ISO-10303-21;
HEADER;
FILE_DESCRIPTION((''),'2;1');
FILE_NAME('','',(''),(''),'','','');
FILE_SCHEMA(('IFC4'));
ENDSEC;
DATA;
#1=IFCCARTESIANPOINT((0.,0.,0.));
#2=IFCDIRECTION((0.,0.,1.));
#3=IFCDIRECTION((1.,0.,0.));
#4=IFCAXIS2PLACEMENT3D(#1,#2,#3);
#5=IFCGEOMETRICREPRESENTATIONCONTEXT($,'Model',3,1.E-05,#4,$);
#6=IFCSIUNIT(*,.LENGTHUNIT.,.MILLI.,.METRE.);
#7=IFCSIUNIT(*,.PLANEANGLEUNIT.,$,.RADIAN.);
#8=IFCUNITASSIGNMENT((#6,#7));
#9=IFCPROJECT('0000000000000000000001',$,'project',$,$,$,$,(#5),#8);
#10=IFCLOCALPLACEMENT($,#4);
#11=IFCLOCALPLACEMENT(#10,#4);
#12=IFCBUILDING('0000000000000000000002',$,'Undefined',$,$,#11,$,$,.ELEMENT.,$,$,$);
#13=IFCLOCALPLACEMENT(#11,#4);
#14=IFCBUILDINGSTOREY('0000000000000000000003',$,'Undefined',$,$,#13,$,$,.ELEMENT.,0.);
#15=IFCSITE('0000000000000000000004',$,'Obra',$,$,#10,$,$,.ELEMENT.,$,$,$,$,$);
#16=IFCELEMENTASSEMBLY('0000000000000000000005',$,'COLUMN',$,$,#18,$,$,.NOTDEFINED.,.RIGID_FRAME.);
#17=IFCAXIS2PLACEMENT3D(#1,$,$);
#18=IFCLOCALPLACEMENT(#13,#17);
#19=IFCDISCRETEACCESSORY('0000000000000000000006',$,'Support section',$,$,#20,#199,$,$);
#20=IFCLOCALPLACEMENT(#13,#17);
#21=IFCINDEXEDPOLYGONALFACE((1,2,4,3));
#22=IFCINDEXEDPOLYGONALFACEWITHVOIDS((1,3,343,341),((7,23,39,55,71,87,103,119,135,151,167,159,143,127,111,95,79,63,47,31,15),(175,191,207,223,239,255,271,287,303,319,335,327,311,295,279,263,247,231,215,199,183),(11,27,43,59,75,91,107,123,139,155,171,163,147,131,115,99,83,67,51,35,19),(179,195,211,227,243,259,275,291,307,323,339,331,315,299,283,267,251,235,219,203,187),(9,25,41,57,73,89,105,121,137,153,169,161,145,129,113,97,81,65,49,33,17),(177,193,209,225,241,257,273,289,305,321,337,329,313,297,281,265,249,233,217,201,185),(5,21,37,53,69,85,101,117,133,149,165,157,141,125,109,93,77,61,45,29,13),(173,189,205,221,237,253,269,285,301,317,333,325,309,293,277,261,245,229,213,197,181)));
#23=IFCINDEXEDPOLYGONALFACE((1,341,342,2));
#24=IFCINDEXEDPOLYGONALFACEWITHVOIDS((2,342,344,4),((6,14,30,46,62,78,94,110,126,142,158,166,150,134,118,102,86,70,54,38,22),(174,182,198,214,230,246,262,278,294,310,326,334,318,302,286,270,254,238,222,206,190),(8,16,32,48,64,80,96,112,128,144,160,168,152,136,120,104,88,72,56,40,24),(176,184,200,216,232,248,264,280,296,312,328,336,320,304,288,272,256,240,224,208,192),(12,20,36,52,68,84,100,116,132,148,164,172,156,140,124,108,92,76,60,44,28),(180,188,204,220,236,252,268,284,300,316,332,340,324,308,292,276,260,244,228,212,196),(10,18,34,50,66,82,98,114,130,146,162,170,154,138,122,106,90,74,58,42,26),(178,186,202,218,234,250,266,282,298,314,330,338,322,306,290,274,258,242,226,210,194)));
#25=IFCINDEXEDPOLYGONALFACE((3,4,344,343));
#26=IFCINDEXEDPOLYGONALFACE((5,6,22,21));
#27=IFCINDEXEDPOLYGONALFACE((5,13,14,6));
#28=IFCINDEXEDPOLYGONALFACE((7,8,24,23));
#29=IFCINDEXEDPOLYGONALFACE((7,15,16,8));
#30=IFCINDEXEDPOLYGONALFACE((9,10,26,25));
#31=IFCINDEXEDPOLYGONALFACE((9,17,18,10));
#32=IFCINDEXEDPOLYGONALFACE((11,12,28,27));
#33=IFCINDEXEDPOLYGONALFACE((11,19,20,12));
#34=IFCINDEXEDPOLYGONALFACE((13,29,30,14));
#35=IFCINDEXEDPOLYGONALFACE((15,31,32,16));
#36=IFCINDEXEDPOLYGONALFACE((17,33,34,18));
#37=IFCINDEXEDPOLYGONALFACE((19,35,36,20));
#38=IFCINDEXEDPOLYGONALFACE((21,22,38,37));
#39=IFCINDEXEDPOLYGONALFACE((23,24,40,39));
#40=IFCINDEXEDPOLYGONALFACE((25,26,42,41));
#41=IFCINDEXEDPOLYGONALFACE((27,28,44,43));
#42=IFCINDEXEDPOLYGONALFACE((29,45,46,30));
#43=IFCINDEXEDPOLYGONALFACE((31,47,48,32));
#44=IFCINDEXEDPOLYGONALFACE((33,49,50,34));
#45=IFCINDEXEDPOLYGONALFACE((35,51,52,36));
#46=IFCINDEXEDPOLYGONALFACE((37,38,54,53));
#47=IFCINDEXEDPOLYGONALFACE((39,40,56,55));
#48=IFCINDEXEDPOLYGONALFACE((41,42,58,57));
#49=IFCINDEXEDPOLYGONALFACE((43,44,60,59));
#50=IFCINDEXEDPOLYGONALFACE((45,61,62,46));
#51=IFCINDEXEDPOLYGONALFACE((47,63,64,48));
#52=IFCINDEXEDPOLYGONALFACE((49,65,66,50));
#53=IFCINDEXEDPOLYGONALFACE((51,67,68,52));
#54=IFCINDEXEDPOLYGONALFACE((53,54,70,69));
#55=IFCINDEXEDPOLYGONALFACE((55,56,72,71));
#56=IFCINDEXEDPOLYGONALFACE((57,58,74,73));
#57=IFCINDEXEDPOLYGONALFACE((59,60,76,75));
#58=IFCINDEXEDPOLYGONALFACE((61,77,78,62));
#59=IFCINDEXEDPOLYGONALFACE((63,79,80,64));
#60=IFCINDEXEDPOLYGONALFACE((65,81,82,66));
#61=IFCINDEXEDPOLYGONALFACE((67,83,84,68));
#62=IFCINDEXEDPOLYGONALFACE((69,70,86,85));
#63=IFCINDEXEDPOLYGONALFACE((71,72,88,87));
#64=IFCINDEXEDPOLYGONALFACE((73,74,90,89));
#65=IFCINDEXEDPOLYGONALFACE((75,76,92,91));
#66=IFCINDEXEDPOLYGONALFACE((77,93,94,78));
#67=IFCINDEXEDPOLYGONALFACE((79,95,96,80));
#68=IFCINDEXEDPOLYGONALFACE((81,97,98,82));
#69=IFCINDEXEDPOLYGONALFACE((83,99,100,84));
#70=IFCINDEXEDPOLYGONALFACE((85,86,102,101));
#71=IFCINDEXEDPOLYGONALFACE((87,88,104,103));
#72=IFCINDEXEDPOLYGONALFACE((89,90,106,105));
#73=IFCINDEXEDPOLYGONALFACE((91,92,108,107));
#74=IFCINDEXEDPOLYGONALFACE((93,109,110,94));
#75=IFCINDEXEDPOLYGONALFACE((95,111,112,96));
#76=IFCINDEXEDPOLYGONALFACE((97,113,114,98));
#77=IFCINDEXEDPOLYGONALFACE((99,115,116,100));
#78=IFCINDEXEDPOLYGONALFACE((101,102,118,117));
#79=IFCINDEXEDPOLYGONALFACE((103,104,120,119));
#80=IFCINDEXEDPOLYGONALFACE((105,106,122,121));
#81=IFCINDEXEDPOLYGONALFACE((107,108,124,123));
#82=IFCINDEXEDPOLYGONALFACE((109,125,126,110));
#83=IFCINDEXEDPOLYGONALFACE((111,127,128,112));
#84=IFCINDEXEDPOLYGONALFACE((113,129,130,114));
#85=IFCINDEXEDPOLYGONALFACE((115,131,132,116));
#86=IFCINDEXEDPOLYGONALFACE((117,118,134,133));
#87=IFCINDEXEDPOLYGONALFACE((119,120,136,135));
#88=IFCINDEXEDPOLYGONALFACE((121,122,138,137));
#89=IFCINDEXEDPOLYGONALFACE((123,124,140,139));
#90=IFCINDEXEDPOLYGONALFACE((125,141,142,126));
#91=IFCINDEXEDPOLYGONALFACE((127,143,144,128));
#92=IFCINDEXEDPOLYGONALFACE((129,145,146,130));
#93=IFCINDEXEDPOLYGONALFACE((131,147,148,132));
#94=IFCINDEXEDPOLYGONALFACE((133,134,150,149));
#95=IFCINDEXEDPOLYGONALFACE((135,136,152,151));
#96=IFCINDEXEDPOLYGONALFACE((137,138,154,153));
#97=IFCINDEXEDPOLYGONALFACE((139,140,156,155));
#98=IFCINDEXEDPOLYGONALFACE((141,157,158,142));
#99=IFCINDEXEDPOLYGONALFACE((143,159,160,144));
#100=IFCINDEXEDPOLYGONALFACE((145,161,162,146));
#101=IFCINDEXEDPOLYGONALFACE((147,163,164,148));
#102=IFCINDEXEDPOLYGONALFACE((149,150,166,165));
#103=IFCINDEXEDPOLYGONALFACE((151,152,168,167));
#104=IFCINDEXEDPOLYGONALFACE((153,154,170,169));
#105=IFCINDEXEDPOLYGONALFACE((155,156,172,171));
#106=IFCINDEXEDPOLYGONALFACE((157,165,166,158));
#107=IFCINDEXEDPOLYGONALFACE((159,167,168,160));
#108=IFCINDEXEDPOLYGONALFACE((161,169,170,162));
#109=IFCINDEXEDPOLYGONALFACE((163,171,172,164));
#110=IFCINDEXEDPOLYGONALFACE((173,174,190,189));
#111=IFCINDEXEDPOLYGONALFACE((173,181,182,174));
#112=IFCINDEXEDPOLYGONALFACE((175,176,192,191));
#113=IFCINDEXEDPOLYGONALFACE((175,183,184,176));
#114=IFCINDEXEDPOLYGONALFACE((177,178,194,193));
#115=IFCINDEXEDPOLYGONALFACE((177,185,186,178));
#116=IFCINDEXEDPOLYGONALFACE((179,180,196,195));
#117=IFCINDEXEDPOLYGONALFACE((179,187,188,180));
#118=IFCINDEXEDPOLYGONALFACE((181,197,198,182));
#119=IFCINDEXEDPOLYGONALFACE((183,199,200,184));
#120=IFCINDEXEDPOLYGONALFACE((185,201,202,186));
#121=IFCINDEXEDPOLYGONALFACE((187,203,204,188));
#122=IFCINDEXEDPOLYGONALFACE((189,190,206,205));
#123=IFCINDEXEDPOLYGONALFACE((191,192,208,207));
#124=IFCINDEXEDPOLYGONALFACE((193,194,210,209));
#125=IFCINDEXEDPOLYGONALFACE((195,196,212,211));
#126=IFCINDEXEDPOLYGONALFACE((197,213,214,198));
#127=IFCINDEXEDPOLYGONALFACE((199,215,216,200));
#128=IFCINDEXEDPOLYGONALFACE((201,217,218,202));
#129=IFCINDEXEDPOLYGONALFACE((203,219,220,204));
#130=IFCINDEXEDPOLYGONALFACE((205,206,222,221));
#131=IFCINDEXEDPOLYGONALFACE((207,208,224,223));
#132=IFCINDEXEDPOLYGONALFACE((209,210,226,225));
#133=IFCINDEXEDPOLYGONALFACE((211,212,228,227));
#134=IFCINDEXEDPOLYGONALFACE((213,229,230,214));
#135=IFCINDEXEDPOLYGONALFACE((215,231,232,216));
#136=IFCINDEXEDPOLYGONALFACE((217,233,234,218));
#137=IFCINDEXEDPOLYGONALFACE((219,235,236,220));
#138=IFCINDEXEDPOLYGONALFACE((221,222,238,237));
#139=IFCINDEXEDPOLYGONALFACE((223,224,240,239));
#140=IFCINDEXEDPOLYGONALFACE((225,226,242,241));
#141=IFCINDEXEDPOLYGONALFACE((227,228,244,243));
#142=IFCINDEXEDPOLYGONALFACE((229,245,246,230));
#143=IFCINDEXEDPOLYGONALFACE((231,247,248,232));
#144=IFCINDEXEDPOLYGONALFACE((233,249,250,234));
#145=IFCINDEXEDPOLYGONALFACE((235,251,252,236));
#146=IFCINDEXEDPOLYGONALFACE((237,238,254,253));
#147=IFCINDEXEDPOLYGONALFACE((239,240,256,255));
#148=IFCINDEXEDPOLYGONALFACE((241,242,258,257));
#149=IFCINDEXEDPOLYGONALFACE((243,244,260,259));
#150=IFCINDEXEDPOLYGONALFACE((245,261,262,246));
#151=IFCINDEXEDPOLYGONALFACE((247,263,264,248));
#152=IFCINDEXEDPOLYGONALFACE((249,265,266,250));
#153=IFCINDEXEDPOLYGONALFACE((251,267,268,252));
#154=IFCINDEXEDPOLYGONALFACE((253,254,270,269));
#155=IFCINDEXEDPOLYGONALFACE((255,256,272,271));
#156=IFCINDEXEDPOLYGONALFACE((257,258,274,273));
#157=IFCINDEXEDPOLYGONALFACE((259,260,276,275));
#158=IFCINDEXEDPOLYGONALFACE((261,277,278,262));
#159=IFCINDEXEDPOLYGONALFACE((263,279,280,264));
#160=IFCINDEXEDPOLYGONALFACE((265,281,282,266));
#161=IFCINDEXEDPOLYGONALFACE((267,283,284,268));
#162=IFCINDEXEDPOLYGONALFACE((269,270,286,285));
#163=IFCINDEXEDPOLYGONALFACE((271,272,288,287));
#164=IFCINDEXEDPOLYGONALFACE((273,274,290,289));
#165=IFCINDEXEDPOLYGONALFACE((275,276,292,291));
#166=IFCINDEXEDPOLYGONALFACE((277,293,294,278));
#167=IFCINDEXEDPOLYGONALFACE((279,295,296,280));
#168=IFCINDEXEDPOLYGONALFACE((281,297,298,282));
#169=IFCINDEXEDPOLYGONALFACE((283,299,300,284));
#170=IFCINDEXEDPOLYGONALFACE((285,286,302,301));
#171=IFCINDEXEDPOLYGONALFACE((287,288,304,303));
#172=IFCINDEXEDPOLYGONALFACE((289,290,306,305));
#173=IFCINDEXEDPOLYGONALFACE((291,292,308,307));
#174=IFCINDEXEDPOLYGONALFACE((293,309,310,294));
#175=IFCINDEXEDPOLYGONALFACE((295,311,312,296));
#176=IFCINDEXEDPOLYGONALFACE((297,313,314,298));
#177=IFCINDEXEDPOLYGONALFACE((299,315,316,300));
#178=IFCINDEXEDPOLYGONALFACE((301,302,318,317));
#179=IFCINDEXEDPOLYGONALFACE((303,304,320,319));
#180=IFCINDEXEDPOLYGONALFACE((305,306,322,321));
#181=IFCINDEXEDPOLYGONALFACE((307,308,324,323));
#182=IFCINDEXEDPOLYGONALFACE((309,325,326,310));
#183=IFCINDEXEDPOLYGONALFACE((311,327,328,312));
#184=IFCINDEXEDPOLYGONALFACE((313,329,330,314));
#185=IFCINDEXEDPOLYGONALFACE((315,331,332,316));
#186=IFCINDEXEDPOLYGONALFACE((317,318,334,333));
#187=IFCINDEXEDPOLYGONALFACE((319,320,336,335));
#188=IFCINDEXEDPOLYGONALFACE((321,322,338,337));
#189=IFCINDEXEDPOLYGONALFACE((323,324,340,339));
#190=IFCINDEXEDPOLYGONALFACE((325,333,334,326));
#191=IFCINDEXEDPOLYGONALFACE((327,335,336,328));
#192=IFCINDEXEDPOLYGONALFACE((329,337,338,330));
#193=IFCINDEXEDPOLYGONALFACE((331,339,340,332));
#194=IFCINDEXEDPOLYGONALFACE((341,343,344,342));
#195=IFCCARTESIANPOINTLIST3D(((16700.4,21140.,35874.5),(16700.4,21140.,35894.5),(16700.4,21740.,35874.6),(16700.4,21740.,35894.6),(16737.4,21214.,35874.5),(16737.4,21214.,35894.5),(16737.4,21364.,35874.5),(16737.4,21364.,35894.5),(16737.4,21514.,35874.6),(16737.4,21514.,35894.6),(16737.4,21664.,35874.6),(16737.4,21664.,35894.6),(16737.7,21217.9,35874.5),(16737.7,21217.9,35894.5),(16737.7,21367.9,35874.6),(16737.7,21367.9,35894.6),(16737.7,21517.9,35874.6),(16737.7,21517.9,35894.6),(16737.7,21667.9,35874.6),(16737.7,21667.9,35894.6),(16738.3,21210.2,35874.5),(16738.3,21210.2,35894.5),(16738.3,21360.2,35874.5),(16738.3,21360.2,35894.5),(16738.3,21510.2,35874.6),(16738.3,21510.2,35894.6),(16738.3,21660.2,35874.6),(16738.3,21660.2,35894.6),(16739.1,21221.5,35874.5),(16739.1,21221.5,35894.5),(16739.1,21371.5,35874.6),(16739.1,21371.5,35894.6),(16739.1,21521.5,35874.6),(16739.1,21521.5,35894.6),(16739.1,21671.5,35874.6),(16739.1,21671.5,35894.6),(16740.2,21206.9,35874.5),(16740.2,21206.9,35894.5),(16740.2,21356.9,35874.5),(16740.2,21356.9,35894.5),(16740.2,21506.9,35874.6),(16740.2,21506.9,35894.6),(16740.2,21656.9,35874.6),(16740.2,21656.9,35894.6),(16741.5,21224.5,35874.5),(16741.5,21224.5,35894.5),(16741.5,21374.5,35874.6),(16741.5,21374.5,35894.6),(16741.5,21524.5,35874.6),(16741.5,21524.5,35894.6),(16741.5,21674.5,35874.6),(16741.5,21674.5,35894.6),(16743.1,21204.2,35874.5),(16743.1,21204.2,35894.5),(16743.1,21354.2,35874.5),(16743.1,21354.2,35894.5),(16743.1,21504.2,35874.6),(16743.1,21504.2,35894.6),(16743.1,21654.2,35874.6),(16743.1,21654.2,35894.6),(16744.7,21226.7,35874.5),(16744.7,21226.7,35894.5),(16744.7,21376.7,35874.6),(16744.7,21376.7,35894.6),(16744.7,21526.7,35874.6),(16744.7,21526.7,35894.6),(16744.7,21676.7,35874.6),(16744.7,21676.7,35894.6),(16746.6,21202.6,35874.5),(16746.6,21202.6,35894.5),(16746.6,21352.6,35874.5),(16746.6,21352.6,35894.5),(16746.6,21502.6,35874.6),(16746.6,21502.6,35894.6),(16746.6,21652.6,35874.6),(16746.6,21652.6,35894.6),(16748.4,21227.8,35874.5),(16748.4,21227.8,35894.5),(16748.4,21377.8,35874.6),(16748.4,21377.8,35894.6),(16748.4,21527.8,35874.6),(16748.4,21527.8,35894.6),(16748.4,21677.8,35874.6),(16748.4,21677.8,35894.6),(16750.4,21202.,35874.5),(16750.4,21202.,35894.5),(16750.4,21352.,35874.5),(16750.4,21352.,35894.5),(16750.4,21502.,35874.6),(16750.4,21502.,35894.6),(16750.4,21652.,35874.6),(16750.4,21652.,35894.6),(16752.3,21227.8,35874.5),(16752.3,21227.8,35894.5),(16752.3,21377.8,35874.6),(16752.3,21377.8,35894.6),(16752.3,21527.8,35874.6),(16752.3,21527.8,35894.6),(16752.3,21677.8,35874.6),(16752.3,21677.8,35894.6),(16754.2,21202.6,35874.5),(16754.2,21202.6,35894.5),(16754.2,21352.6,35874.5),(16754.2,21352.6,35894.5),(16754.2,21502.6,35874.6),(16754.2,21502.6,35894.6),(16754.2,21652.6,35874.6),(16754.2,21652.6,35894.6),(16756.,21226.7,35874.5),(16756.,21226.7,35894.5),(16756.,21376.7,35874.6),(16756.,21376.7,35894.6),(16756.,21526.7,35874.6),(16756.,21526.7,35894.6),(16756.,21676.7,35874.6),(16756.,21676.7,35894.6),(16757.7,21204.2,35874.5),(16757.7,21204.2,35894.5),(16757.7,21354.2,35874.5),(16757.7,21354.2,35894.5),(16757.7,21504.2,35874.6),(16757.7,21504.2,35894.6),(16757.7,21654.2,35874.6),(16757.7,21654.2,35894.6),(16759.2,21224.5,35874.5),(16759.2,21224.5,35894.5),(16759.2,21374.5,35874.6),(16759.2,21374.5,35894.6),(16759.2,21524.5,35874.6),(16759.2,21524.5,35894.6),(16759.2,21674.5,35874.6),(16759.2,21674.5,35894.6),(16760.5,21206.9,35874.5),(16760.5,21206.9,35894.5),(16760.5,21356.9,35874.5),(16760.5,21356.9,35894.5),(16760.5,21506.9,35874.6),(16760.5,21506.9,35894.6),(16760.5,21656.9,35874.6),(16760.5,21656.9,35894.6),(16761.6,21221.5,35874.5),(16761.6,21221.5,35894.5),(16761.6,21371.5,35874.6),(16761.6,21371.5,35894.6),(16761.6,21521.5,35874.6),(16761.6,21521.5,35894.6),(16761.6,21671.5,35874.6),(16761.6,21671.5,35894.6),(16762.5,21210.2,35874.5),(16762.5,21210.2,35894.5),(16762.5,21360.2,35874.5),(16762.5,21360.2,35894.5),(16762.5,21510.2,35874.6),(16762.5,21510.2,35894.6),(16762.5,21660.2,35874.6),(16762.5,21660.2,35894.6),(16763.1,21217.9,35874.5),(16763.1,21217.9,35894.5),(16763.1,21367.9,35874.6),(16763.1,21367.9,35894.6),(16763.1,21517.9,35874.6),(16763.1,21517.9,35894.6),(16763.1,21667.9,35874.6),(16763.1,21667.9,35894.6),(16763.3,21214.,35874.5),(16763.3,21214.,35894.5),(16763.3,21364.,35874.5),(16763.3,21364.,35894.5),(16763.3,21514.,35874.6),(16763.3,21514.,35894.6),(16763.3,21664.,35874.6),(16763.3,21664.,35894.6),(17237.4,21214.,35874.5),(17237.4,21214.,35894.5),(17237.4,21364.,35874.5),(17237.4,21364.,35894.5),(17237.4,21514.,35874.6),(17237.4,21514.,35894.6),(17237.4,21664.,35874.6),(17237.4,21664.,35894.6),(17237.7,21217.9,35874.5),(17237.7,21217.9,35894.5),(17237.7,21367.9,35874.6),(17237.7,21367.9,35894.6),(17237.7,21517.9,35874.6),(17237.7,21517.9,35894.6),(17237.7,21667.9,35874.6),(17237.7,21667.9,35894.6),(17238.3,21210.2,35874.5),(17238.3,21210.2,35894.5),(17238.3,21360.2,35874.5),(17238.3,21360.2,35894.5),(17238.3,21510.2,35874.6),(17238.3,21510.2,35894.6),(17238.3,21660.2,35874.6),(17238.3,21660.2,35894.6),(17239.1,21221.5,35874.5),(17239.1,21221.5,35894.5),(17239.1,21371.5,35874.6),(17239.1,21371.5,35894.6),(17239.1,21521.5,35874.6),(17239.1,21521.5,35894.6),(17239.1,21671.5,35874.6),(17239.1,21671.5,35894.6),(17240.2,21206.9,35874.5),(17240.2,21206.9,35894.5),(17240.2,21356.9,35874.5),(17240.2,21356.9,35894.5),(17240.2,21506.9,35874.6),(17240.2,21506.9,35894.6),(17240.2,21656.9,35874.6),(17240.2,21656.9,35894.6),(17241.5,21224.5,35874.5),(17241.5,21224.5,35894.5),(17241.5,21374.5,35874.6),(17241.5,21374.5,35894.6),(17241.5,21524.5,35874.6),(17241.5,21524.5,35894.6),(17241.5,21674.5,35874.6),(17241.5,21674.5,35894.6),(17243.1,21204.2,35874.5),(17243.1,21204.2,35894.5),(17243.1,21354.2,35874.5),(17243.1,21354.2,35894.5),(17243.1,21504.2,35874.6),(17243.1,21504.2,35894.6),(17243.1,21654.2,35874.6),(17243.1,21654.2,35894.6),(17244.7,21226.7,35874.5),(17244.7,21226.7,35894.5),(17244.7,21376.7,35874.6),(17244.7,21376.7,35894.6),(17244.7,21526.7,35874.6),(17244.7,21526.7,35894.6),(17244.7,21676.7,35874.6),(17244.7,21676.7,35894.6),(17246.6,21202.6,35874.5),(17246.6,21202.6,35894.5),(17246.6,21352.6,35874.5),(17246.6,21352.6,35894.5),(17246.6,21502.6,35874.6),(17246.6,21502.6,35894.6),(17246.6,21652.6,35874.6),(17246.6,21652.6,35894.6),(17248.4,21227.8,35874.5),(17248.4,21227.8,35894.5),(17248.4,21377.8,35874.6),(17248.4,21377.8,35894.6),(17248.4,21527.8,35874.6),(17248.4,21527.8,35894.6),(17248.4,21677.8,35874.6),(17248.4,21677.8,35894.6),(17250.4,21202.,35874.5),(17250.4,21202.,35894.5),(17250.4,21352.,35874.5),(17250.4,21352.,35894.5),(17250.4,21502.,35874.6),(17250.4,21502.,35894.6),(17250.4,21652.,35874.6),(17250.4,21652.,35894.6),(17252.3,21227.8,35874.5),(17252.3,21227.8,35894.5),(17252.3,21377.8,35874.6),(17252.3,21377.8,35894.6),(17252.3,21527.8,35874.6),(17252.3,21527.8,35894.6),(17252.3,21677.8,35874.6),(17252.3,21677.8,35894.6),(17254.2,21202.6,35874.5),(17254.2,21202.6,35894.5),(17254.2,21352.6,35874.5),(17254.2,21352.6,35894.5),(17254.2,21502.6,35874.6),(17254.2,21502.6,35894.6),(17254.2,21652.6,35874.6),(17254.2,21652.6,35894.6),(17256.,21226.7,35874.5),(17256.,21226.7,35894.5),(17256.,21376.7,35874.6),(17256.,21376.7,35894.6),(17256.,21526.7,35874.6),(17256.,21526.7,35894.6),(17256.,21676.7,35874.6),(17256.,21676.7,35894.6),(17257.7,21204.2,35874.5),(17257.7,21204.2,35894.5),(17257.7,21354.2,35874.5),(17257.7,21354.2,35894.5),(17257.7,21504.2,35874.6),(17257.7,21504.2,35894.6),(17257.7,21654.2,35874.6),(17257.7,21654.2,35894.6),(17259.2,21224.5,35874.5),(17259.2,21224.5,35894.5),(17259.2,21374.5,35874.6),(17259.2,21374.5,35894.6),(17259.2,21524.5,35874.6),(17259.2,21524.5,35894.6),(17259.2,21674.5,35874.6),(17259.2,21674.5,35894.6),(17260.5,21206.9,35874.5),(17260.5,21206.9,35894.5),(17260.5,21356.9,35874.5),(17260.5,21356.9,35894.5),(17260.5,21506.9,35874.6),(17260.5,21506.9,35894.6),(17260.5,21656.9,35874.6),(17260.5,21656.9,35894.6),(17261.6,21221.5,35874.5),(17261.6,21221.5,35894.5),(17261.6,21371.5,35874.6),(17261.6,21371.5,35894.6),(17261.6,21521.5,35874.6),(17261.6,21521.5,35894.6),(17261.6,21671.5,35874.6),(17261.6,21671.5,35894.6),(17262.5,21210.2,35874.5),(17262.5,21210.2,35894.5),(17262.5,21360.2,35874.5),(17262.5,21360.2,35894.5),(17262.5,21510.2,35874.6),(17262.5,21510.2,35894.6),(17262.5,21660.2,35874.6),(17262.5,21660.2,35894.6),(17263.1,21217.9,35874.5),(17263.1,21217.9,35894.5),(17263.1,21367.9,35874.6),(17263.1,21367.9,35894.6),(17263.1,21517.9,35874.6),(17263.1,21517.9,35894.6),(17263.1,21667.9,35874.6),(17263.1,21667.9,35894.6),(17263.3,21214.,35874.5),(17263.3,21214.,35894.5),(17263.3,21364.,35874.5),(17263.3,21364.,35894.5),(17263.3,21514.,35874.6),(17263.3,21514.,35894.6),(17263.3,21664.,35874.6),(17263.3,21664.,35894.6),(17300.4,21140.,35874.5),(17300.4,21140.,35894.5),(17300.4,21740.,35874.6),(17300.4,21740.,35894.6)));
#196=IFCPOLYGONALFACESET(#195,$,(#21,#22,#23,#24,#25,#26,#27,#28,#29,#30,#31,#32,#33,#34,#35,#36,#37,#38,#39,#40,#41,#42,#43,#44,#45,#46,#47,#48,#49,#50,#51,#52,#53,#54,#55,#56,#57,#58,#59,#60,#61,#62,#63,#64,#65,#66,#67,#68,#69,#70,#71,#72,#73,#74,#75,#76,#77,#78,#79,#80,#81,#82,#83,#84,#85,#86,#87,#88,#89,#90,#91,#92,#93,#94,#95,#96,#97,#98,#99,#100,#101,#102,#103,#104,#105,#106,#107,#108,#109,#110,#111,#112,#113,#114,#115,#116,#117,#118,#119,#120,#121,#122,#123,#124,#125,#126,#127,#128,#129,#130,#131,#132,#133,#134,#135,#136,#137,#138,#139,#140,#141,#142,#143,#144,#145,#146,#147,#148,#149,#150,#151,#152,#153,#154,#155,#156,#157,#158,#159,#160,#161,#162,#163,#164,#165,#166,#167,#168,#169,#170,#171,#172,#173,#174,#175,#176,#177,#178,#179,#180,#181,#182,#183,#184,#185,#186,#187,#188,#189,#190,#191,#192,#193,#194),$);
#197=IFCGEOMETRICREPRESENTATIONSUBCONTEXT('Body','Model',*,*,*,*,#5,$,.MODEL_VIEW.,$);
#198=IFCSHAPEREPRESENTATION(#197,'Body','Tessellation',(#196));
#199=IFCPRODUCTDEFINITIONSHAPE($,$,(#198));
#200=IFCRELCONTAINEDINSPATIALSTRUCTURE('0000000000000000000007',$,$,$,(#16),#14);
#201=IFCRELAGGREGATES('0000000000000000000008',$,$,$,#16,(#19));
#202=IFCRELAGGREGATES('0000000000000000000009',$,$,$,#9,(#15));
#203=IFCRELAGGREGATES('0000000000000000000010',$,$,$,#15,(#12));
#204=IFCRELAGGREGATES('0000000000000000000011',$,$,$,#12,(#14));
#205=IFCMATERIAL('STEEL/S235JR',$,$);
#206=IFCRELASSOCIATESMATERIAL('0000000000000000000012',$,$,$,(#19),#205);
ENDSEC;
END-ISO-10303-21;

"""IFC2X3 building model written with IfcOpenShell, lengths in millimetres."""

from ifc_helpers import new_model, si_unit, frame, origin_with_axes, origin_2d_with_axis, place, context, subcontext, project, spatial, rectangle, circle, extrude, source, transform, mapped, material, element, aggregate, save


model = new_model("IFC2X3")

# Units and contexts
model_context = context("Model", 3, precision=1e-05, world=origin_with_axes())
body_context = subcontext(model_context, "Body", "Model", "MODEL_VIEW")
ifc_project = project(units=[si_unit("LENGTHUNIT", "METRE", prefix="MILLI"), si_unit("PLANEANGLEUNIT", "RADIAN")], contexts=[model_context])

# Site, building, storey
site_placement = place(None, origin_with_axes())
site = spatial("IfcSite", under=ifc_project, at=site_placement, Name="Obra", CompositionType="ELEMENT")
building_placement = place(site_placement, origin_with_axes())
building = spatial("IfcBuilding", under=site, at=building_placement, Name="Undefined", CompositionType="ELEMENT")
storey_placement = place(building_placement, origin_with_axes())
storey = spatial("IfcBuildingStorey", under=building, at=storey_placement, Name="Undefined", CompositionType="ELEMENT", Elevation=0.0)

# Element assembly
assembly_1_placement = place(storey_placement, origin_with_axes())
assembly_1 = element("IfcElementAssembly", 1, at=assembly_1_placement, inside=storey, Name="COLUMN", AssemblyPlace="NOTDEFINED", PredefinedType="RIGID_FRAME")
ifc_material_1 = material(Name="STEEL/S235JR")

# Discrete accessory, opening
discrete_accessory_1_placement = place(assembly_1_placement, frame((17000.4, 21140.0, 35884.5), z_axis=(1.0, 0.0, 0.0), x_axis=(0.0, 1.0, 0.000195)))
discrete_accessory_1 = element("IfcDiscreteAccessory", 2, at=discrete_accessory_1_placement, material=ifc_material_1, Name="Support section", context=body_context, shape_type="SweptSolid", body=[
    extrude(rectangle(XDim=20.0, YDim=600.0, at=origin_2d_with_axis()), frame((600.0, 0.0, 0.0), z_axis=(-1.0, 0.0, 0.0), x_axis=(0.0, -1.0, 0.0)), (0.0, 0.0, 1.0), 600.0),
])
shared_shape_1 = source(origin_with_axes(), body_context, "Body", "SweptSolid", [
    extrude(circle(Radius=13.0, at=origin_2d_with_axis()), frame((0.0, -0.1, 0.0), z_axis=(0.0, 1.0, 0.0), x_axis=(1.0, 0.0, 0.0)), (0.0, 0.0, 1.0), 20.2),
])
opening_1_placement = place(assembly_1_placement, frame((17000.4, 21592.5, 35894.6), z_axis=(1.0, 0.0, 0.0), x_axis=(0.0, -1.0, -0.000195)))
element("IfcOpeningElement", 3, at=opening_1_placement, cuts=discrete_accessory_1, ObjectType="Opening", context=body_context, shape_type="MappedRepresentation", body=[
    mapped(shared_shape_1, transform((-72.5, 0.0, -250.0))),
    mapped(shared_shape_1, transform((-72.5, 0.0, 250.0))),
    mapped(shared_shape_1, transform((77.5, 0.0, -250.0))),
    mapped(shared_shape_1, transform((77.5, 0.0, 250.0))),
    mapped(shared_shape_1, transform((227.5, 0.0, -250.0))),
    mapped(shared_shape_1, transform((227.5, 0.0, 250.0))),
    mapped(shared_shape_1, transform((377.5, 0.0, -250.0))),
    mapped(shared_shape_1, transform((377.5, 0.0, 250.0))),
])

aggregate(assembly_1, [discrete_accessory_1])

save(model, "model.ifc")
